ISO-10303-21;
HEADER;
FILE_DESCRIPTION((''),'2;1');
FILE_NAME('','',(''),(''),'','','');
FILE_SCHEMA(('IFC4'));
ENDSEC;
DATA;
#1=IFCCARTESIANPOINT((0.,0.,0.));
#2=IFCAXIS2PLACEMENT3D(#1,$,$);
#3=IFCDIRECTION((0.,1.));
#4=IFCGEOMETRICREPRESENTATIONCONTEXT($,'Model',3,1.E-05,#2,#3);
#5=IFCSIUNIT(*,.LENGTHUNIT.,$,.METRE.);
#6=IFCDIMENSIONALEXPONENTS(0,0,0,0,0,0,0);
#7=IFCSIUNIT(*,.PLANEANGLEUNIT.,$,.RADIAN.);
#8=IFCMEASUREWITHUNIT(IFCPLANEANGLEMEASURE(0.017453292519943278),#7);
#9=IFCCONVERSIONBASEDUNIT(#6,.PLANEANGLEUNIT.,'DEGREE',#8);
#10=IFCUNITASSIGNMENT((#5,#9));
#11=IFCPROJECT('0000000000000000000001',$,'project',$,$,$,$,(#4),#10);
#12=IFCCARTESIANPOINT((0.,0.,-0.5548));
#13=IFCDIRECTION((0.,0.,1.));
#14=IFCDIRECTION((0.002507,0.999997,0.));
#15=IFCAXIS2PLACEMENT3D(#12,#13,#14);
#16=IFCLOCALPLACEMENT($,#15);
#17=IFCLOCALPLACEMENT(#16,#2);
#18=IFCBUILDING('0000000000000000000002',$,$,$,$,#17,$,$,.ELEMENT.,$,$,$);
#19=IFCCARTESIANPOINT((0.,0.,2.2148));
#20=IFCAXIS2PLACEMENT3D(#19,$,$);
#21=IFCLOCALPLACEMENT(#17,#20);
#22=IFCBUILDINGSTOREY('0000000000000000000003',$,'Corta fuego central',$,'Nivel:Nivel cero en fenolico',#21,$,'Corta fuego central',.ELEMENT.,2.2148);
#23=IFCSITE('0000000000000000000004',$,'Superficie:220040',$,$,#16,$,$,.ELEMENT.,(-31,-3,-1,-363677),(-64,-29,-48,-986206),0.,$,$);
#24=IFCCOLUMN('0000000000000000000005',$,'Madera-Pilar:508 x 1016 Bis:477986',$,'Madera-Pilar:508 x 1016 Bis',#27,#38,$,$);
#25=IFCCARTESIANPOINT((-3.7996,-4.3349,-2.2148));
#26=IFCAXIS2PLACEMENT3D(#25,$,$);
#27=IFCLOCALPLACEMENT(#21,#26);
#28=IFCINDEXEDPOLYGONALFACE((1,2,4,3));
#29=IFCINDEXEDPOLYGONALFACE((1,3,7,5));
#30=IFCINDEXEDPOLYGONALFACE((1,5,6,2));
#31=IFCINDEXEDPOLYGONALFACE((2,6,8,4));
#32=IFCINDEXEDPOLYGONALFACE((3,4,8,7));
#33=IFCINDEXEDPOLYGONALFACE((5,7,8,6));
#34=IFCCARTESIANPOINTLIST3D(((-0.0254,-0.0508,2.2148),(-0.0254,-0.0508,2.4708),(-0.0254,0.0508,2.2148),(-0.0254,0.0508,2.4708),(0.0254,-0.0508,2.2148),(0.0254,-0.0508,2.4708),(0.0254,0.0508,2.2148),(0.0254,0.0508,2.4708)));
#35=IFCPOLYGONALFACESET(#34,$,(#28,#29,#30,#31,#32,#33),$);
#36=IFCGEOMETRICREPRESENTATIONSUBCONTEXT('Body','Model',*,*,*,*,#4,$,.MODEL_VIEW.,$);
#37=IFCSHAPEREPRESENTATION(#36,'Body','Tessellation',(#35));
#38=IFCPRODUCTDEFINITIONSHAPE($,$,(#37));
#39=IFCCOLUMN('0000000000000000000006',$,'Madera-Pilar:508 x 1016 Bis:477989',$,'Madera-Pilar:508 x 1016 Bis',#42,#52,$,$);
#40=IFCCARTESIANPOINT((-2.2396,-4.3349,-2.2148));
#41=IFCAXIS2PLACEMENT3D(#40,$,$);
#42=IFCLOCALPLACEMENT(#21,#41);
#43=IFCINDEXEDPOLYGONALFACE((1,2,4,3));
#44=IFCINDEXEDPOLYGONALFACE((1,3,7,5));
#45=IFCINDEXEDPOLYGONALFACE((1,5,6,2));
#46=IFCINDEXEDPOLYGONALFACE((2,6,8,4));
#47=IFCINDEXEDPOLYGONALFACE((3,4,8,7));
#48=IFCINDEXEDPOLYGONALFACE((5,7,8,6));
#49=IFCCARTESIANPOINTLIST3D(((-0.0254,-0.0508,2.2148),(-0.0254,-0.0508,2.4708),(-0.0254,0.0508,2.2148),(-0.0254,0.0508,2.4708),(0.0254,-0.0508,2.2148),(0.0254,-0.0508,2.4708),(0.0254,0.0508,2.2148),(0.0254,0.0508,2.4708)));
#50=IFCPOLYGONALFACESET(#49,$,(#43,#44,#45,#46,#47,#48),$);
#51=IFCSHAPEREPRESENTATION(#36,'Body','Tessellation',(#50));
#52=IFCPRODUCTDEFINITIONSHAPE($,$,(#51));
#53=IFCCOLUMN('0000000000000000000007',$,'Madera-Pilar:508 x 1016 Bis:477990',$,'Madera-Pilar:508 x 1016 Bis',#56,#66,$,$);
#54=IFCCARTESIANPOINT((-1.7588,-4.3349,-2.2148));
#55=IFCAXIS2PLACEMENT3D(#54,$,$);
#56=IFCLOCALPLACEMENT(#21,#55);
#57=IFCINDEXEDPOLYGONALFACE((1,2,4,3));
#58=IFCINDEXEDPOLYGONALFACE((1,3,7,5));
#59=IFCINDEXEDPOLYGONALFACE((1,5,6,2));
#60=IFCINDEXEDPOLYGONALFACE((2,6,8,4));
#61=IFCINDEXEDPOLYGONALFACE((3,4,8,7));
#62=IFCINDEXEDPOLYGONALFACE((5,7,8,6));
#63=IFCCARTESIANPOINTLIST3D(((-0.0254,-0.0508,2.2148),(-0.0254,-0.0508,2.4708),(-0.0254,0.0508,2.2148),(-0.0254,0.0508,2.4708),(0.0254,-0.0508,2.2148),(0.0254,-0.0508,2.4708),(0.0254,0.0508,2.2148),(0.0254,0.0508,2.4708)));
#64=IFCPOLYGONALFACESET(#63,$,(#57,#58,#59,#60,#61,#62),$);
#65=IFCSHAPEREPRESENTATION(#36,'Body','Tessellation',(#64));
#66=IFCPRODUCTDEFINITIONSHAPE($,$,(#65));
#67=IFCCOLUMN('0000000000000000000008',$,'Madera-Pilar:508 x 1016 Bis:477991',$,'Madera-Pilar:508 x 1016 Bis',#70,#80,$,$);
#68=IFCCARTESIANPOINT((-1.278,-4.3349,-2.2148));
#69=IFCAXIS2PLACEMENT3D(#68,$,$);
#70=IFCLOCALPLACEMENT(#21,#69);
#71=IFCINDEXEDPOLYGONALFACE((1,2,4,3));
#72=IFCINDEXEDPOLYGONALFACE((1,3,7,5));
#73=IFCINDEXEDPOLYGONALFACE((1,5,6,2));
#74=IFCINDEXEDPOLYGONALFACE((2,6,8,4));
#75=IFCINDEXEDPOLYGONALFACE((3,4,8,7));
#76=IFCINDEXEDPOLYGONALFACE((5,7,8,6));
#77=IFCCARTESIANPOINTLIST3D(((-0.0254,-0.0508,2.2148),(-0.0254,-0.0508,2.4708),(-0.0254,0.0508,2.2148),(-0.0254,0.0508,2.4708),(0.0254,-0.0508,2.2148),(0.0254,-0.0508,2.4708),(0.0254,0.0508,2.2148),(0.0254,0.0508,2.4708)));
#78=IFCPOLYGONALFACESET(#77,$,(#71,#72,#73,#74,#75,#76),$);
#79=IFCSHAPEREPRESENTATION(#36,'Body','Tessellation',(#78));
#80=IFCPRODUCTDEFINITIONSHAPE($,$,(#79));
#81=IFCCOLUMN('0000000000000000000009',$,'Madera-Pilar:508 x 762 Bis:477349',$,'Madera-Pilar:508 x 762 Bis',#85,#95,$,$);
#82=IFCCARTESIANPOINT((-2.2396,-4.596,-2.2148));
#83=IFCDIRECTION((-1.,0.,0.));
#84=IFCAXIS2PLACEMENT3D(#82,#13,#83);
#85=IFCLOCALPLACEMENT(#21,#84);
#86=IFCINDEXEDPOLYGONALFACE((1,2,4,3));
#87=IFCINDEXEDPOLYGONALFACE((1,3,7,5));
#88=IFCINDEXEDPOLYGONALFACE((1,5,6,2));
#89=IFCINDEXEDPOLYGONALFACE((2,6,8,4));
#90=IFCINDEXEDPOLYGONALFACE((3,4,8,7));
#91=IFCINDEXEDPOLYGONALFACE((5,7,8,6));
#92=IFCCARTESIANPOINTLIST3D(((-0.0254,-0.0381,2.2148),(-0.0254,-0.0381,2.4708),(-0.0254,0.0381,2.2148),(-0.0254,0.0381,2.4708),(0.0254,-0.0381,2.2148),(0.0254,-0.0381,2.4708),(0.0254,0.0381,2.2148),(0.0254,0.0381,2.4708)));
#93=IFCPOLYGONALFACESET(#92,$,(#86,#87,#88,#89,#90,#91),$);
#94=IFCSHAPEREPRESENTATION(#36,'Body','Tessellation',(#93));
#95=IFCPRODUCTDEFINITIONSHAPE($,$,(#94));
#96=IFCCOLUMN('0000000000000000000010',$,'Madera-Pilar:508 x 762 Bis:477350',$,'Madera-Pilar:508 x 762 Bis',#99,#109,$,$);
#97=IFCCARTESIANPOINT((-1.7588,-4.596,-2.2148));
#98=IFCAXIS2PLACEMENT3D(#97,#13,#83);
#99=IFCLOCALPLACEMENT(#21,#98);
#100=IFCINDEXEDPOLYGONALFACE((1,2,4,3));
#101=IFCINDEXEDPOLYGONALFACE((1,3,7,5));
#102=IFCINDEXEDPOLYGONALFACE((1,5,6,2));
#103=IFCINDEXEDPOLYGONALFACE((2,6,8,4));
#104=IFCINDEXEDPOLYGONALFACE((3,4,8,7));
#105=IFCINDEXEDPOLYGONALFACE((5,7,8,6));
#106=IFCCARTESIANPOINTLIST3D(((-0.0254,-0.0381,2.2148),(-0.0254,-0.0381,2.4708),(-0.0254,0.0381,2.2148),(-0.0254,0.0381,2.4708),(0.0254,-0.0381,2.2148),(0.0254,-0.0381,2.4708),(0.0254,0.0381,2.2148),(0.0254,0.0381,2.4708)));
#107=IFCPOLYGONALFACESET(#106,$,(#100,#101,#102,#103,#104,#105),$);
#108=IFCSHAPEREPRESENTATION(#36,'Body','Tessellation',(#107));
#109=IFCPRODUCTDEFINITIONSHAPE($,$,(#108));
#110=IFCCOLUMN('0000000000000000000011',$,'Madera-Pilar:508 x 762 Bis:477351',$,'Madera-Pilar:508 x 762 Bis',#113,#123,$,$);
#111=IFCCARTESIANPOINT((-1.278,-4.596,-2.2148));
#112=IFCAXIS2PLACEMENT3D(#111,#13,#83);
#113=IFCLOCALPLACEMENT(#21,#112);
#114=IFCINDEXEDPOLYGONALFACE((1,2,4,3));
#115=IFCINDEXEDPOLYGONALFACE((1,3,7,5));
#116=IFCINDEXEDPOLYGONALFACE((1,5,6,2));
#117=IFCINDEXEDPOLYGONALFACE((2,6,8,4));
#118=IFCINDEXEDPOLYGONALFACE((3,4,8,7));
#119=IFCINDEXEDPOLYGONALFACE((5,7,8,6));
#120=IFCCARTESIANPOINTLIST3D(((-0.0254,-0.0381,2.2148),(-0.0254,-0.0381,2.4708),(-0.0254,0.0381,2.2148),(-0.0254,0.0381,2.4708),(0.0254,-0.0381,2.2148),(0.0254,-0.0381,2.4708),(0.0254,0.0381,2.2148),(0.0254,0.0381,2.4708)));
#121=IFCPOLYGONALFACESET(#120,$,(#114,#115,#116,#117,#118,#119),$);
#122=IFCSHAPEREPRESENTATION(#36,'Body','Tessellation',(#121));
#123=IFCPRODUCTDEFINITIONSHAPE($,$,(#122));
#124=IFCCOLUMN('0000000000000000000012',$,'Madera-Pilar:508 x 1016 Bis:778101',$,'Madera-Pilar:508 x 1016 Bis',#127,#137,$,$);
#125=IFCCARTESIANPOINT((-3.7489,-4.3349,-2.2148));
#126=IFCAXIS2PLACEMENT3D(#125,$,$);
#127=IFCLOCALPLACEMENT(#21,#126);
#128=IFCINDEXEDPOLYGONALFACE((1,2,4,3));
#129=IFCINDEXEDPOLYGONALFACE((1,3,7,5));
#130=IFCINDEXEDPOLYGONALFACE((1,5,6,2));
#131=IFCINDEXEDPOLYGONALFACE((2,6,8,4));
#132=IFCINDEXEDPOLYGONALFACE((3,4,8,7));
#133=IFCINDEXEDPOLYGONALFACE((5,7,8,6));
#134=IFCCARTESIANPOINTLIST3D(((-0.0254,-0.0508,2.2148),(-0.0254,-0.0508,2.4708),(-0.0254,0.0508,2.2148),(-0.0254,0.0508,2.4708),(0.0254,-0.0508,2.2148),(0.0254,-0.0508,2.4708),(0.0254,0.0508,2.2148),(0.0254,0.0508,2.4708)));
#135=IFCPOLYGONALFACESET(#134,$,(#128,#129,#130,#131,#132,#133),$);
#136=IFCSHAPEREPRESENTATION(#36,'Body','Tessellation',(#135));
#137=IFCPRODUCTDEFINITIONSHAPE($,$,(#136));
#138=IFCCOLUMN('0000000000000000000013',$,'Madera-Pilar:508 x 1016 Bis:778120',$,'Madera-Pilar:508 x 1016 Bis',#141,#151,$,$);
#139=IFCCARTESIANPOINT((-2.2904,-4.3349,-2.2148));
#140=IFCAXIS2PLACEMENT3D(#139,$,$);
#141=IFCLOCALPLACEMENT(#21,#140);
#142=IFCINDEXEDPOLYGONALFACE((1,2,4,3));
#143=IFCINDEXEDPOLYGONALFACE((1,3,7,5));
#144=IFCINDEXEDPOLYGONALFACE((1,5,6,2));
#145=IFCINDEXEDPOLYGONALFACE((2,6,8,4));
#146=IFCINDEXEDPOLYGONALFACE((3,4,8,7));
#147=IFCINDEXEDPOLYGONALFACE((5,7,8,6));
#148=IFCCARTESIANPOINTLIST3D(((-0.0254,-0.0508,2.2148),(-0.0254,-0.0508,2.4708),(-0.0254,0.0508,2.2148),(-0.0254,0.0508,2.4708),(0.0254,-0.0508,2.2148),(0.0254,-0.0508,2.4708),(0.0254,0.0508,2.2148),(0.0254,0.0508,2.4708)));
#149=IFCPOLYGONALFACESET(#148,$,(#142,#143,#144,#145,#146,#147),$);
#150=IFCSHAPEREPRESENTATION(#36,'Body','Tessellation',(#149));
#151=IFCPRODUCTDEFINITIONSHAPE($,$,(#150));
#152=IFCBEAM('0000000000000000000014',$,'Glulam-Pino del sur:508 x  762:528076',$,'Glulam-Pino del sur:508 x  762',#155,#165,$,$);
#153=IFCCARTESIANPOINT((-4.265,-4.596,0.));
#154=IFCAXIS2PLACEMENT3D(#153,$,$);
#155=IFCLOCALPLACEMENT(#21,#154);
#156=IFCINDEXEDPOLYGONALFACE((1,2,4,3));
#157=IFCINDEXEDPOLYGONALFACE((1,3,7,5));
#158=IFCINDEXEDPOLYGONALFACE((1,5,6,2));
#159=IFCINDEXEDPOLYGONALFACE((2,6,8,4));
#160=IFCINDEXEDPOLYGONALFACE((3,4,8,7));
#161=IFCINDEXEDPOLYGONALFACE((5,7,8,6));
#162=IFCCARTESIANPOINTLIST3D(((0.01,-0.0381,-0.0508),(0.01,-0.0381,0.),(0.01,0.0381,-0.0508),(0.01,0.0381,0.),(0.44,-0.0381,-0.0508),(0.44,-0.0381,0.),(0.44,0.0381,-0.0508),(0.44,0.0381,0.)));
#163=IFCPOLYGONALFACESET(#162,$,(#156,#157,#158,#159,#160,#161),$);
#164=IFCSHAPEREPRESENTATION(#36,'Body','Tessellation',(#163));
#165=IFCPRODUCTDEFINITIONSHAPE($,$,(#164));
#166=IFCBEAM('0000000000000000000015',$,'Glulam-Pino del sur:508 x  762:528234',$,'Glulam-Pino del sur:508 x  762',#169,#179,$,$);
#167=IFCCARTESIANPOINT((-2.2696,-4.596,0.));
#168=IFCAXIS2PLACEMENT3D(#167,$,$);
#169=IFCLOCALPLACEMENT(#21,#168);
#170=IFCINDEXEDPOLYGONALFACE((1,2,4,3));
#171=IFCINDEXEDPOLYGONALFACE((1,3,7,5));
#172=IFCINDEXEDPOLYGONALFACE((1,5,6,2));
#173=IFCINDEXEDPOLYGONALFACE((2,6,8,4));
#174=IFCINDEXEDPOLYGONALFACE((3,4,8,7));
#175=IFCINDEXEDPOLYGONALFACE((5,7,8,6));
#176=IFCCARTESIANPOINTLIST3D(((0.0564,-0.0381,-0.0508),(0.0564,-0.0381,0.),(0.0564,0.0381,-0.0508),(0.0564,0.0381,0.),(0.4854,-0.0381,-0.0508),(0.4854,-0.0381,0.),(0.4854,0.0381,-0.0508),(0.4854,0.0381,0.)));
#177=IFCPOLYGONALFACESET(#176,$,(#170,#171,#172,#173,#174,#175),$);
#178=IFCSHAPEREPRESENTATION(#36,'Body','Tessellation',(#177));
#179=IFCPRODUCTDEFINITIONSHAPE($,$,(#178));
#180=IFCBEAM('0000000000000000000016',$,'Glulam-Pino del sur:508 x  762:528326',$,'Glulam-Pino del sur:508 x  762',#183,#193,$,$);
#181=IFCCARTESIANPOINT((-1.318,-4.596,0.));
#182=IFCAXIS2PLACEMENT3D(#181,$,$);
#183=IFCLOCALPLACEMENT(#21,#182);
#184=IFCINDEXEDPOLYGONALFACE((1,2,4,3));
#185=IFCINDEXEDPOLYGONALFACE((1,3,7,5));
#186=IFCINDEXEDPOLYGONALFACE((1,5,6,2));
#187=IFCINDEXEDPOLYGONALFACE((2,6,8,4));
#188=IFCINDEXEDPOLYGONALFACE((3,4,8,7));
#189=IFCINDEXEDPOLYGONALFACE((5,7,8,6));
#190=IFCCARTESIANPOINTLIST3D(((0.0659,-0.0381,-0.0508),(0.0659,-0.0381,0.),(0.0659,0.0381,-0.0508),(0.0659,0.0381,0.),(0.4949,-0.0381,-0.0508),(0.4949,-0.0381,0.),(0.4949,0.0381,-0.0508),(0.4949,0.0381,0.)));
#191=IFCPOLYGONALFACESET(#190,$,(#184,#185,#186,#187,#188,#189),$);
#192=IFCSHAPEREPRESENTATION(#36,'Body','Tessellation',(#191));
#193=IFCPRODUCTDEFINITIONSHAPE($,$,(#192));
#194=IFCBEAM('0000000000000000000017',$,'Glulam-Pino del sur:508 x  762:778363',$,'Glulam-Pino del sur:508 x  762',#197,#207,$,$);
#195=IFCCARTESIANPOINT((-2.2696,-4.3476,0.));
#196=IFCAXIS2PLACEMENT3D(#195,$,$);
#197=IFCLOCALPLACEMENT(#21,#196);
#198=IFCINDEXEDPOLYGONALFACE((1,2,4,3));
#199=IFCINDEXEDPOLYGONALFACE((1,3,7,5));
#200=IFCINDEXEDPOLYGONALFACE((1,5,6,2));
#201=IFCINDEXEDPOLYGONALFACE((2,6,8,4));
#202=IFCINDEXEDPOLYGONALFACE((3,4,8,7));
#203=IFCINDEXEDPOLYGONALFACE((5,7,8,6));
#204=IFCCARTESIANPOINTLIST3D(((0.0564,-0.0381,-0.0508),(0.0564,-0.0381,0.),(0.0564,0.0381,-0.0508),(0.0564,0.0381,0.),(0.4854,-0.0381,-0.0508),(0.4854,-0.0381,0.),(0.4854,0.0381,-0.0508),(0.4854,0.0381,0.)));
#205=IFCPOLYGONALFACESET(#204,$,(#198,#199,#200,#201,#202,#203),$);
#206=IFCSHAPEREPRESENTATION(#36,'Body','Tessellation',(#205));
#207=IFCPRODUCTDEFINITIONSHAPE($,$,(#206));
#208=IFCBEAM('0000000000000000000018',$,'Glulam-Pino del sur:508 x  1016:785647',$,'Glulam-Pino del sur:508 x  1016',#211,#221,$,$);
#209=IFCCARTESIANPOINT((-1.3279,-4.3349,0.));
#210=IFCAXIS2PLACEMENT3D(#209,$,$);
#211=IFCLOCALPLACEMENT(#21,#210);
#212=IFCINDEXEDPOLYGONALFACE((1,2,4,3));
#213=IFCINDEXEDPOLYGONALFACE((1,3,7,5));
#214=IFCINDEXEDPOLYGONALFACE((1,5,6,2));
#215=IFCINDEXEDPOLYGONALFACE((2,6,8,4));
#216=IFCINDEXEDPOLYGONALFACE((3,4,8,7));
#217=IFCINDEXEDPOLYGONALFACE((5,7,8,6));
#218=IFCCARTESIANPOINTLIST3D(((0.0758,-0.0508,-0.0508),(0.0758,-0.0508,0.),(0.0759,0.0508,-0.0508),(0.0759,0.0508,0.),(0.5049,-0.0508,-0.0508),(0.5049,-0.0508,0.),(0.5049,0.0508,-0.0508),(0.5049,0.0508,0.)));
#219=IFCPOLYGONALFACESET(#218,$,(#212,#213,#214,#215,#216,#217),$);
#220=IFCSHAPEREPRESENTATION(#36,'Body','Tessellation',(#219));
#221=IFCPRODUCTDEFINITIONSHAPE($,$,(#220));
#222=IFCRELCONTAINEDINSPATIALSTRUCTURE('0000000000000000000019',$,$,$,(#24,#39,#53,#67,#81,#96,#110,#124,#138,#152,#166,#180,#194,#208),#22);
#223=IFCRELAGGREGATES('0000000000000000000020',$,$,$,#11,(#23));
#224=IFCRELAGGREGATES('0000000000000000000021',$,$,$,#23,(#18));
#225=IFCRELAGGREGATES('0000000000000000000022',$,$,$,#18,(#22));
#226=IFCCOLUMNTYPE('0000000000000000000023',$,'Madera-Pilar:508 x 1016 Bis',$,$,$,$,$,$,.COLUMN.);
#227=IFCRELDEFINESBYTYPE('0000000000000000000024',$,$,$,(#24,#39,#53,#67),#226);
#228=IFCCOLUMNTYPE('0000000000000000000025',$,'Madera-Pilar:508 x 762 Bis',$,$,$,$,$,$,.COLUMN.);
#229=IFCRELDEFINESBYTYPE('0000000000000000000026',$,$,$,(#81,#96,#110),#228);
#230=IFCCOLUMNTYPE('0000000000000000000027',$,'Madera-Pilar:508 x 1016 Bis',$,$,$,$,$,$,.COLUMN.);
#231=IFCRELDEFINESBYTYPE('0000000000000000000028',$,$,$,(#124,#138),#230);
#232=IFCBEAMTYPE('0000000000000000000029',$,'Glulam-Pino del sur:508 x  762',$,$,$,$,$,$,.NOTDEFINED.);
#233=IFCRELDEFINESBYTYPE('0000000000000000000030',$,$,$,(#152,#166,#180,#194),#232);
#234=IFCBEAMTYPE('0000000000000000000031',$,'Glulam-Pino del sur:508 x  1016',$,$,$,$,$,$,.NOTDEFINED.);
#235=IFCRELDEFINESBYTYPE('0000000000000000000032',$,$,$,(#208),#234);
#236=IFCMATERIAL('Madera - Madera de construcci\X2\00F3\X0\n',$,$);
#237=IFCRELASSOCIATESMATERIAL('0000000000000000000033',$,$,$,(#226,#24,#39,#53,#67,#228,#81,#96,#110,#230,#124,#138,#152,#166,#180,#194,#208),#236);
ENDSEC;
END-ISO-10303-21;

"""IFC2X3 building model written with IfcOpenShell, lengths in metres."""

from ifc_helpers import new_model, entity, si_unit, converted_unit, direction, frame, frame_2d, origin, origin_2d_with_axis, place, context, subcontext, project, spatial, rectangle, extrude, source, transform, mapped, material, type_object, type_shapes, element, save


model = new_model("IFC2X3")

# Units and contexts
model_context = context("Model", 3, precision=1e-05, world=origin(), true_north=direction((0.0, 1.0)))
body_context = subcontext(model_context, "Body", "Model", "MODEL_VIEW")
ifc_project = project(units=[si_unit("LENGTHUNIT", "METRE"), converted_unit("PLANEANGLEUNIT", "DEGREE", entity("IfcPlaneAngleMeasure", 0.017453292519943278), si_unit("PLANEANGLEUNIT", "RADIAN"), dimensions=[0, 0, 0, 0, 0, 0, 0])], contexts=[model_context])

# Site, building, storey
site_placement = place(None, frame((0.0, 0.0, -0.5548), z_axis=(0.0, 0.0, 1.0), x_axis=(0.002507, 0.999997, 0.0)))
site = spatial("IfcSite", under=ifc_project, at=site_placement, Name="Superficie:220040", CompositionType="ELEMENT", RefLatitude=(-31, -3, -1, -363677), RefLongitude=(-64, -29, -48, -986206), RefElevation=0.0)
building_placement = place(site_placement, origin())
building = spatial("IfcBuilding", under=site, at=building_placement, CompositionType="ELEMENT")
storey_placement = place(building_placement, frame((0.0, 0.0, 2.2148)))
storey = spatial("IfcBuildingStorey", under=building, at=storey_placement, Name="Corta fuego central", ObjectType="Nivel:Nivel cero en fenolico", LongName="Corta fuego central", CompositionType="ELEMENT", Elevation=2.2148)

# Columns
ifc_material_1 = material(Name="Madera - Madera de construcción")
column_type_1 = type_object("IfcColumnType", Name="Madera-Pilar:508 x 1016 Bis", PredefinedType="COLUMN", material=ifc_material_1)
shared_shape_1 = source(origin(), body_context, "Body", "SweptSolid", [
    extrude(rectangle(XDim=0.0508, YDim=0.1016, at=origin_2d_with_axis()), frame((0.0, 0.0, 2.2148), z_axis=(0.0, 0.0, 1.0), x_axis=(-1.0, 0.0, 0.0)), (0.0, 0.0, 1.0), 0.256),
])
type_shapes(column_type_1, [shared_shape_1])
for number, where, name in (
    (1, (-3.7996, -4.3349, -2.2148), "Madera-Pilar:508 x 1016 Bis:477986"),
    (2, (-2.2396, -4.3349, -2.2148), "Madera-Pilar:508 x 1016 Bis:477989"),
    (3, (-1.7588, -4.3349, -2.2148), "Madera-Pilar:508 x 1016 Bis:477990"),
    (4, (-1.278, -4.3349, -2.2148), "Madera-Pilar:508 x 1016 Bis:477991"),
):
    element("IfcColumn", number, at=place(storey_placement, frame(where)), inside=storey, type_object=column_type_1, material=ifc_material_1, Name=name, ObjectType="Madera-Pilar:508 x 1016 Bis", context=body_context, shape_type="MappedRepresentation", body=[
        mapped(shared_shape_1, transform((0.0, 0.0, 0.0), scale=1.0)),
    ])
column_type_2 = type_object("IfcColumnType", Name="Madera-Pilar:508 x 762 Bis", PredefinedType="COLUMN", material=ifc_material_1)
shared_shape_2 = source(origin(), body_context, "Body", "SweptSolid", [
    extrude(rectangle(XDim=0.0508, YDim=0.0762, at=frame_2d((0.0, 0.0), x_axis=(1.0, 0.0))), frame((0.0, 0.0, 2.2148), z_axis=(0.0, 0.0, 1.0), x_axis=(-1.0, 0.0, 0.0)), (0.0, 0.0, 1.0), 0.256),
])
type_shapes(column_type_2, [shared_shape_2])
for number, where, z_axis, x_axis, name in (
    (5, (-2.2396, -4.596, -2.2148), (0.0, 0.0, 1.0), (-1.0, 0.0, 0.0), "Madera-Pilar:508 x 762 Bis:477349"),
    (6, (-1.7588, -4.596, -2.2148), (0.0, 0.0, 1.0), (-1.0, 0.0, 0.0), "Madera-Pilar:508 x 762 Bis:477350"),
    (7, (-1.278, -4.596, -2.2148), (0.0, 0.0, 1.0), (-1.0, 0.0, 0.0), "Madera-Pilar:508 x 762 Bis:477351"),
):
    element("IfcColumn", number, at=place(storey_placement, frame(where, z_axis=z_axis, x_axis=x_axis)), inside=storey, type_object=column_type_2, material=ifc_material_1, Name=name, ObjectType="Madera-Pilar:508 x 762 Bis", context=body_context, shape_type="MappedRepresentation", body=[
        mapped(shared_shape_2, transform((0.0, 0.0, 0.0), scale=1.0)),
    ])
column_type_3 = type_object("IfcColumnType", Name="Madera-Pilar:508 x 1016 Bis", PredefinedType="COLUMN", material=ifc_material_1)
shared_shape_3 = source(origin(), body_context, "Body", "SweptSolid", [
    extrude(rectangle(XDim=0.0508, YDim=0.1016, at=frame_2d((0.0, 0.0), x_axis=(1.0, 0.0))), frame((0.0, 0.0, 2.2148), z_axis=(0.0, 0.0, 1.0), x_axis=(-1.0, 0.0, 0.0)), (0.0, 0.0, 1.0), 0.256),
])
type_shapes(column_type_3, [shared_shape_3])
for number, where, name in (
    (8, (-3.7489, -4.3349, -2.2148), "Madera-Pilar:508 x 1016 Bis:778101"),
    (9, (-2.2904, -4.3349, -2.2148), "Madera-Pilar:508 x 1016 Bis:778120"),
):
    element("IfcColumn", number, at=place(storey_placement, frame(where)), inside=storey, type_object=column_type_3, material=ifc_material_1, Name=name, ObjectType="Madera-Pilar:508 x 1016 Bis", context=body_context, shape_type="MappedRepresentation", body=[
        mapped(shared_shape_3, transform((0.0, 0.0, 0.0), scale=1.0)),
    ])

# Beams
beam_type_1 = type_object("IfcBeamType", Name="Glulam-Pino del sur:508 x  762", PredefinedType="NOTDEFINED")
beam_1_placement = place(storey_placement, frame((-4.265, -4.596, 0.0)))
element("IfcBeam", 10, at=beam_1_placement, inside=storey, type_object=beam_type_1, material=ifc_material_1, Name="Glulam-Pino del sur:508 x  762:528076", ObjectType="Glulam-Pino del sur:508 x  762", context=body_context, shape_type="SweptSolid", body=[
    extrude(rectangle(XDim=0.0508, YDim=0.0762, at=frame_2d((0.0, 0.0), x_axis=(1.0, 0.0))), frame((0.01, 0.0, -0.0254), z_axis=(1.0, 0.0, 0.0), x_axis=(0.0, 0.0, -1.0)), (0.0, 0.0, 1.0), 0.43),
])
beam_2_placement = place(storey_placement, frame((-2.2696, -4.596, 0.0)))
element("IfcBeam", 11, at=beam_2_placement, inside=storey, type_object=beam_type_1, material=ifc_material_1, Name="Glulam-Pino del sur:508 x  762:528234", ObjectType="Glulam-Pino del sur:508 x  762", context=body_context, shape_type="SweptSolid", body=[
    extrude(rectangle(XDim=0.0508, YDim=0.0762, at=frame_2d((0.0, 0.0), x_axis=(1.0, 0.0))), frame((0.0564, 0.0, -0.0254), z_axis=(1.0, 0.0, 0.0), x_axis=(0.0, 0.0, -1.0)), (0.0, 0.0, 1.0), 0.429),
])
beam_3_placement = place(storey_placement, frame((-1.318, -4.596, 0.0)))
element("IfcBeam", 12, at=beam_3_placement, inside=storey, type_object=beam_type_1, material=ifc_material_1, Name="Glulam-Pino del sur:508 x  762:528326", ObjectType="Glulam-Pino del sur:508 x  762", context=body_context, shape_type="SweptSolid", body=[
    extrude(rectangle(XDim=0.0508, YDim=0.0762, at=frame_2d((0.0, 0.0), x_axis=(1.0, 0.0))), frame((0.0659, 0.0, -0.0254), z_axis=(1.0, 0.0, 0.0), x_axis=(0.0, 0.0, -1.0)), (0.0, 0.0, 1.0), 0.429),
])
beam_4_placement = place(storey_placement, frame((-2.2696, -4.3476, 0.0)))
element("IfcBeam", 13, at=beam_4_placement, inside=storey, type_object=beam_type_1, material=ifc_material_1, Name="Glulam-Pino del sur:508 x  762:778363", ObjectType="Glulam-Pino del sur:508 x  762", context=body_context, shape_type="SweptSolid", body=[
    extrude(rectangle(XDim=0.0508, YDim=0.0762, at=frame_2d((0.0, 0.0), x_axis=(1.0, 0.0))), frame((0.0564, 0.0, -0.0254), z_axis=(1.0, 0.0, 0.0), x_axis=(0.0, 0.0, -1.0)), (0.0, 0.0, 1.0), 0.429),
])
beam_type_2 = type_object("IfcBeamType", Name="Glulam-Pino del sur:508 x  1016", PredefinedType="NOTDEFINED")
beam_5_placement = place(storey_placement, frame((-1.3279, -4.3349, 0.0)))
element("IfcBeam", 14, at=beam_5_placement, inside=storey, type_object=beam_type_2, material=ifc_material_1, Name="Glulam-Pino del sur:508 x  1016:785647", ObjectType="Glulam-Pino del sur:508 x  1016", context=body_context, shape_type="SweptSolid", body=[
    extrude(rectangle(XDim=0.0508, YDim=0.1016, at=frame_2d((0.0, 0.0), x_axis=(1.0, 0.0))), frame((0.0759, 0.0, -0.0254), z_axis=(1.0, 0.0, 0.0), x_axis=(0.0, 0.0, -1.0)), (0.0, 0.0, 1.0), 0.429),
])

save(model, "model.ifc")
